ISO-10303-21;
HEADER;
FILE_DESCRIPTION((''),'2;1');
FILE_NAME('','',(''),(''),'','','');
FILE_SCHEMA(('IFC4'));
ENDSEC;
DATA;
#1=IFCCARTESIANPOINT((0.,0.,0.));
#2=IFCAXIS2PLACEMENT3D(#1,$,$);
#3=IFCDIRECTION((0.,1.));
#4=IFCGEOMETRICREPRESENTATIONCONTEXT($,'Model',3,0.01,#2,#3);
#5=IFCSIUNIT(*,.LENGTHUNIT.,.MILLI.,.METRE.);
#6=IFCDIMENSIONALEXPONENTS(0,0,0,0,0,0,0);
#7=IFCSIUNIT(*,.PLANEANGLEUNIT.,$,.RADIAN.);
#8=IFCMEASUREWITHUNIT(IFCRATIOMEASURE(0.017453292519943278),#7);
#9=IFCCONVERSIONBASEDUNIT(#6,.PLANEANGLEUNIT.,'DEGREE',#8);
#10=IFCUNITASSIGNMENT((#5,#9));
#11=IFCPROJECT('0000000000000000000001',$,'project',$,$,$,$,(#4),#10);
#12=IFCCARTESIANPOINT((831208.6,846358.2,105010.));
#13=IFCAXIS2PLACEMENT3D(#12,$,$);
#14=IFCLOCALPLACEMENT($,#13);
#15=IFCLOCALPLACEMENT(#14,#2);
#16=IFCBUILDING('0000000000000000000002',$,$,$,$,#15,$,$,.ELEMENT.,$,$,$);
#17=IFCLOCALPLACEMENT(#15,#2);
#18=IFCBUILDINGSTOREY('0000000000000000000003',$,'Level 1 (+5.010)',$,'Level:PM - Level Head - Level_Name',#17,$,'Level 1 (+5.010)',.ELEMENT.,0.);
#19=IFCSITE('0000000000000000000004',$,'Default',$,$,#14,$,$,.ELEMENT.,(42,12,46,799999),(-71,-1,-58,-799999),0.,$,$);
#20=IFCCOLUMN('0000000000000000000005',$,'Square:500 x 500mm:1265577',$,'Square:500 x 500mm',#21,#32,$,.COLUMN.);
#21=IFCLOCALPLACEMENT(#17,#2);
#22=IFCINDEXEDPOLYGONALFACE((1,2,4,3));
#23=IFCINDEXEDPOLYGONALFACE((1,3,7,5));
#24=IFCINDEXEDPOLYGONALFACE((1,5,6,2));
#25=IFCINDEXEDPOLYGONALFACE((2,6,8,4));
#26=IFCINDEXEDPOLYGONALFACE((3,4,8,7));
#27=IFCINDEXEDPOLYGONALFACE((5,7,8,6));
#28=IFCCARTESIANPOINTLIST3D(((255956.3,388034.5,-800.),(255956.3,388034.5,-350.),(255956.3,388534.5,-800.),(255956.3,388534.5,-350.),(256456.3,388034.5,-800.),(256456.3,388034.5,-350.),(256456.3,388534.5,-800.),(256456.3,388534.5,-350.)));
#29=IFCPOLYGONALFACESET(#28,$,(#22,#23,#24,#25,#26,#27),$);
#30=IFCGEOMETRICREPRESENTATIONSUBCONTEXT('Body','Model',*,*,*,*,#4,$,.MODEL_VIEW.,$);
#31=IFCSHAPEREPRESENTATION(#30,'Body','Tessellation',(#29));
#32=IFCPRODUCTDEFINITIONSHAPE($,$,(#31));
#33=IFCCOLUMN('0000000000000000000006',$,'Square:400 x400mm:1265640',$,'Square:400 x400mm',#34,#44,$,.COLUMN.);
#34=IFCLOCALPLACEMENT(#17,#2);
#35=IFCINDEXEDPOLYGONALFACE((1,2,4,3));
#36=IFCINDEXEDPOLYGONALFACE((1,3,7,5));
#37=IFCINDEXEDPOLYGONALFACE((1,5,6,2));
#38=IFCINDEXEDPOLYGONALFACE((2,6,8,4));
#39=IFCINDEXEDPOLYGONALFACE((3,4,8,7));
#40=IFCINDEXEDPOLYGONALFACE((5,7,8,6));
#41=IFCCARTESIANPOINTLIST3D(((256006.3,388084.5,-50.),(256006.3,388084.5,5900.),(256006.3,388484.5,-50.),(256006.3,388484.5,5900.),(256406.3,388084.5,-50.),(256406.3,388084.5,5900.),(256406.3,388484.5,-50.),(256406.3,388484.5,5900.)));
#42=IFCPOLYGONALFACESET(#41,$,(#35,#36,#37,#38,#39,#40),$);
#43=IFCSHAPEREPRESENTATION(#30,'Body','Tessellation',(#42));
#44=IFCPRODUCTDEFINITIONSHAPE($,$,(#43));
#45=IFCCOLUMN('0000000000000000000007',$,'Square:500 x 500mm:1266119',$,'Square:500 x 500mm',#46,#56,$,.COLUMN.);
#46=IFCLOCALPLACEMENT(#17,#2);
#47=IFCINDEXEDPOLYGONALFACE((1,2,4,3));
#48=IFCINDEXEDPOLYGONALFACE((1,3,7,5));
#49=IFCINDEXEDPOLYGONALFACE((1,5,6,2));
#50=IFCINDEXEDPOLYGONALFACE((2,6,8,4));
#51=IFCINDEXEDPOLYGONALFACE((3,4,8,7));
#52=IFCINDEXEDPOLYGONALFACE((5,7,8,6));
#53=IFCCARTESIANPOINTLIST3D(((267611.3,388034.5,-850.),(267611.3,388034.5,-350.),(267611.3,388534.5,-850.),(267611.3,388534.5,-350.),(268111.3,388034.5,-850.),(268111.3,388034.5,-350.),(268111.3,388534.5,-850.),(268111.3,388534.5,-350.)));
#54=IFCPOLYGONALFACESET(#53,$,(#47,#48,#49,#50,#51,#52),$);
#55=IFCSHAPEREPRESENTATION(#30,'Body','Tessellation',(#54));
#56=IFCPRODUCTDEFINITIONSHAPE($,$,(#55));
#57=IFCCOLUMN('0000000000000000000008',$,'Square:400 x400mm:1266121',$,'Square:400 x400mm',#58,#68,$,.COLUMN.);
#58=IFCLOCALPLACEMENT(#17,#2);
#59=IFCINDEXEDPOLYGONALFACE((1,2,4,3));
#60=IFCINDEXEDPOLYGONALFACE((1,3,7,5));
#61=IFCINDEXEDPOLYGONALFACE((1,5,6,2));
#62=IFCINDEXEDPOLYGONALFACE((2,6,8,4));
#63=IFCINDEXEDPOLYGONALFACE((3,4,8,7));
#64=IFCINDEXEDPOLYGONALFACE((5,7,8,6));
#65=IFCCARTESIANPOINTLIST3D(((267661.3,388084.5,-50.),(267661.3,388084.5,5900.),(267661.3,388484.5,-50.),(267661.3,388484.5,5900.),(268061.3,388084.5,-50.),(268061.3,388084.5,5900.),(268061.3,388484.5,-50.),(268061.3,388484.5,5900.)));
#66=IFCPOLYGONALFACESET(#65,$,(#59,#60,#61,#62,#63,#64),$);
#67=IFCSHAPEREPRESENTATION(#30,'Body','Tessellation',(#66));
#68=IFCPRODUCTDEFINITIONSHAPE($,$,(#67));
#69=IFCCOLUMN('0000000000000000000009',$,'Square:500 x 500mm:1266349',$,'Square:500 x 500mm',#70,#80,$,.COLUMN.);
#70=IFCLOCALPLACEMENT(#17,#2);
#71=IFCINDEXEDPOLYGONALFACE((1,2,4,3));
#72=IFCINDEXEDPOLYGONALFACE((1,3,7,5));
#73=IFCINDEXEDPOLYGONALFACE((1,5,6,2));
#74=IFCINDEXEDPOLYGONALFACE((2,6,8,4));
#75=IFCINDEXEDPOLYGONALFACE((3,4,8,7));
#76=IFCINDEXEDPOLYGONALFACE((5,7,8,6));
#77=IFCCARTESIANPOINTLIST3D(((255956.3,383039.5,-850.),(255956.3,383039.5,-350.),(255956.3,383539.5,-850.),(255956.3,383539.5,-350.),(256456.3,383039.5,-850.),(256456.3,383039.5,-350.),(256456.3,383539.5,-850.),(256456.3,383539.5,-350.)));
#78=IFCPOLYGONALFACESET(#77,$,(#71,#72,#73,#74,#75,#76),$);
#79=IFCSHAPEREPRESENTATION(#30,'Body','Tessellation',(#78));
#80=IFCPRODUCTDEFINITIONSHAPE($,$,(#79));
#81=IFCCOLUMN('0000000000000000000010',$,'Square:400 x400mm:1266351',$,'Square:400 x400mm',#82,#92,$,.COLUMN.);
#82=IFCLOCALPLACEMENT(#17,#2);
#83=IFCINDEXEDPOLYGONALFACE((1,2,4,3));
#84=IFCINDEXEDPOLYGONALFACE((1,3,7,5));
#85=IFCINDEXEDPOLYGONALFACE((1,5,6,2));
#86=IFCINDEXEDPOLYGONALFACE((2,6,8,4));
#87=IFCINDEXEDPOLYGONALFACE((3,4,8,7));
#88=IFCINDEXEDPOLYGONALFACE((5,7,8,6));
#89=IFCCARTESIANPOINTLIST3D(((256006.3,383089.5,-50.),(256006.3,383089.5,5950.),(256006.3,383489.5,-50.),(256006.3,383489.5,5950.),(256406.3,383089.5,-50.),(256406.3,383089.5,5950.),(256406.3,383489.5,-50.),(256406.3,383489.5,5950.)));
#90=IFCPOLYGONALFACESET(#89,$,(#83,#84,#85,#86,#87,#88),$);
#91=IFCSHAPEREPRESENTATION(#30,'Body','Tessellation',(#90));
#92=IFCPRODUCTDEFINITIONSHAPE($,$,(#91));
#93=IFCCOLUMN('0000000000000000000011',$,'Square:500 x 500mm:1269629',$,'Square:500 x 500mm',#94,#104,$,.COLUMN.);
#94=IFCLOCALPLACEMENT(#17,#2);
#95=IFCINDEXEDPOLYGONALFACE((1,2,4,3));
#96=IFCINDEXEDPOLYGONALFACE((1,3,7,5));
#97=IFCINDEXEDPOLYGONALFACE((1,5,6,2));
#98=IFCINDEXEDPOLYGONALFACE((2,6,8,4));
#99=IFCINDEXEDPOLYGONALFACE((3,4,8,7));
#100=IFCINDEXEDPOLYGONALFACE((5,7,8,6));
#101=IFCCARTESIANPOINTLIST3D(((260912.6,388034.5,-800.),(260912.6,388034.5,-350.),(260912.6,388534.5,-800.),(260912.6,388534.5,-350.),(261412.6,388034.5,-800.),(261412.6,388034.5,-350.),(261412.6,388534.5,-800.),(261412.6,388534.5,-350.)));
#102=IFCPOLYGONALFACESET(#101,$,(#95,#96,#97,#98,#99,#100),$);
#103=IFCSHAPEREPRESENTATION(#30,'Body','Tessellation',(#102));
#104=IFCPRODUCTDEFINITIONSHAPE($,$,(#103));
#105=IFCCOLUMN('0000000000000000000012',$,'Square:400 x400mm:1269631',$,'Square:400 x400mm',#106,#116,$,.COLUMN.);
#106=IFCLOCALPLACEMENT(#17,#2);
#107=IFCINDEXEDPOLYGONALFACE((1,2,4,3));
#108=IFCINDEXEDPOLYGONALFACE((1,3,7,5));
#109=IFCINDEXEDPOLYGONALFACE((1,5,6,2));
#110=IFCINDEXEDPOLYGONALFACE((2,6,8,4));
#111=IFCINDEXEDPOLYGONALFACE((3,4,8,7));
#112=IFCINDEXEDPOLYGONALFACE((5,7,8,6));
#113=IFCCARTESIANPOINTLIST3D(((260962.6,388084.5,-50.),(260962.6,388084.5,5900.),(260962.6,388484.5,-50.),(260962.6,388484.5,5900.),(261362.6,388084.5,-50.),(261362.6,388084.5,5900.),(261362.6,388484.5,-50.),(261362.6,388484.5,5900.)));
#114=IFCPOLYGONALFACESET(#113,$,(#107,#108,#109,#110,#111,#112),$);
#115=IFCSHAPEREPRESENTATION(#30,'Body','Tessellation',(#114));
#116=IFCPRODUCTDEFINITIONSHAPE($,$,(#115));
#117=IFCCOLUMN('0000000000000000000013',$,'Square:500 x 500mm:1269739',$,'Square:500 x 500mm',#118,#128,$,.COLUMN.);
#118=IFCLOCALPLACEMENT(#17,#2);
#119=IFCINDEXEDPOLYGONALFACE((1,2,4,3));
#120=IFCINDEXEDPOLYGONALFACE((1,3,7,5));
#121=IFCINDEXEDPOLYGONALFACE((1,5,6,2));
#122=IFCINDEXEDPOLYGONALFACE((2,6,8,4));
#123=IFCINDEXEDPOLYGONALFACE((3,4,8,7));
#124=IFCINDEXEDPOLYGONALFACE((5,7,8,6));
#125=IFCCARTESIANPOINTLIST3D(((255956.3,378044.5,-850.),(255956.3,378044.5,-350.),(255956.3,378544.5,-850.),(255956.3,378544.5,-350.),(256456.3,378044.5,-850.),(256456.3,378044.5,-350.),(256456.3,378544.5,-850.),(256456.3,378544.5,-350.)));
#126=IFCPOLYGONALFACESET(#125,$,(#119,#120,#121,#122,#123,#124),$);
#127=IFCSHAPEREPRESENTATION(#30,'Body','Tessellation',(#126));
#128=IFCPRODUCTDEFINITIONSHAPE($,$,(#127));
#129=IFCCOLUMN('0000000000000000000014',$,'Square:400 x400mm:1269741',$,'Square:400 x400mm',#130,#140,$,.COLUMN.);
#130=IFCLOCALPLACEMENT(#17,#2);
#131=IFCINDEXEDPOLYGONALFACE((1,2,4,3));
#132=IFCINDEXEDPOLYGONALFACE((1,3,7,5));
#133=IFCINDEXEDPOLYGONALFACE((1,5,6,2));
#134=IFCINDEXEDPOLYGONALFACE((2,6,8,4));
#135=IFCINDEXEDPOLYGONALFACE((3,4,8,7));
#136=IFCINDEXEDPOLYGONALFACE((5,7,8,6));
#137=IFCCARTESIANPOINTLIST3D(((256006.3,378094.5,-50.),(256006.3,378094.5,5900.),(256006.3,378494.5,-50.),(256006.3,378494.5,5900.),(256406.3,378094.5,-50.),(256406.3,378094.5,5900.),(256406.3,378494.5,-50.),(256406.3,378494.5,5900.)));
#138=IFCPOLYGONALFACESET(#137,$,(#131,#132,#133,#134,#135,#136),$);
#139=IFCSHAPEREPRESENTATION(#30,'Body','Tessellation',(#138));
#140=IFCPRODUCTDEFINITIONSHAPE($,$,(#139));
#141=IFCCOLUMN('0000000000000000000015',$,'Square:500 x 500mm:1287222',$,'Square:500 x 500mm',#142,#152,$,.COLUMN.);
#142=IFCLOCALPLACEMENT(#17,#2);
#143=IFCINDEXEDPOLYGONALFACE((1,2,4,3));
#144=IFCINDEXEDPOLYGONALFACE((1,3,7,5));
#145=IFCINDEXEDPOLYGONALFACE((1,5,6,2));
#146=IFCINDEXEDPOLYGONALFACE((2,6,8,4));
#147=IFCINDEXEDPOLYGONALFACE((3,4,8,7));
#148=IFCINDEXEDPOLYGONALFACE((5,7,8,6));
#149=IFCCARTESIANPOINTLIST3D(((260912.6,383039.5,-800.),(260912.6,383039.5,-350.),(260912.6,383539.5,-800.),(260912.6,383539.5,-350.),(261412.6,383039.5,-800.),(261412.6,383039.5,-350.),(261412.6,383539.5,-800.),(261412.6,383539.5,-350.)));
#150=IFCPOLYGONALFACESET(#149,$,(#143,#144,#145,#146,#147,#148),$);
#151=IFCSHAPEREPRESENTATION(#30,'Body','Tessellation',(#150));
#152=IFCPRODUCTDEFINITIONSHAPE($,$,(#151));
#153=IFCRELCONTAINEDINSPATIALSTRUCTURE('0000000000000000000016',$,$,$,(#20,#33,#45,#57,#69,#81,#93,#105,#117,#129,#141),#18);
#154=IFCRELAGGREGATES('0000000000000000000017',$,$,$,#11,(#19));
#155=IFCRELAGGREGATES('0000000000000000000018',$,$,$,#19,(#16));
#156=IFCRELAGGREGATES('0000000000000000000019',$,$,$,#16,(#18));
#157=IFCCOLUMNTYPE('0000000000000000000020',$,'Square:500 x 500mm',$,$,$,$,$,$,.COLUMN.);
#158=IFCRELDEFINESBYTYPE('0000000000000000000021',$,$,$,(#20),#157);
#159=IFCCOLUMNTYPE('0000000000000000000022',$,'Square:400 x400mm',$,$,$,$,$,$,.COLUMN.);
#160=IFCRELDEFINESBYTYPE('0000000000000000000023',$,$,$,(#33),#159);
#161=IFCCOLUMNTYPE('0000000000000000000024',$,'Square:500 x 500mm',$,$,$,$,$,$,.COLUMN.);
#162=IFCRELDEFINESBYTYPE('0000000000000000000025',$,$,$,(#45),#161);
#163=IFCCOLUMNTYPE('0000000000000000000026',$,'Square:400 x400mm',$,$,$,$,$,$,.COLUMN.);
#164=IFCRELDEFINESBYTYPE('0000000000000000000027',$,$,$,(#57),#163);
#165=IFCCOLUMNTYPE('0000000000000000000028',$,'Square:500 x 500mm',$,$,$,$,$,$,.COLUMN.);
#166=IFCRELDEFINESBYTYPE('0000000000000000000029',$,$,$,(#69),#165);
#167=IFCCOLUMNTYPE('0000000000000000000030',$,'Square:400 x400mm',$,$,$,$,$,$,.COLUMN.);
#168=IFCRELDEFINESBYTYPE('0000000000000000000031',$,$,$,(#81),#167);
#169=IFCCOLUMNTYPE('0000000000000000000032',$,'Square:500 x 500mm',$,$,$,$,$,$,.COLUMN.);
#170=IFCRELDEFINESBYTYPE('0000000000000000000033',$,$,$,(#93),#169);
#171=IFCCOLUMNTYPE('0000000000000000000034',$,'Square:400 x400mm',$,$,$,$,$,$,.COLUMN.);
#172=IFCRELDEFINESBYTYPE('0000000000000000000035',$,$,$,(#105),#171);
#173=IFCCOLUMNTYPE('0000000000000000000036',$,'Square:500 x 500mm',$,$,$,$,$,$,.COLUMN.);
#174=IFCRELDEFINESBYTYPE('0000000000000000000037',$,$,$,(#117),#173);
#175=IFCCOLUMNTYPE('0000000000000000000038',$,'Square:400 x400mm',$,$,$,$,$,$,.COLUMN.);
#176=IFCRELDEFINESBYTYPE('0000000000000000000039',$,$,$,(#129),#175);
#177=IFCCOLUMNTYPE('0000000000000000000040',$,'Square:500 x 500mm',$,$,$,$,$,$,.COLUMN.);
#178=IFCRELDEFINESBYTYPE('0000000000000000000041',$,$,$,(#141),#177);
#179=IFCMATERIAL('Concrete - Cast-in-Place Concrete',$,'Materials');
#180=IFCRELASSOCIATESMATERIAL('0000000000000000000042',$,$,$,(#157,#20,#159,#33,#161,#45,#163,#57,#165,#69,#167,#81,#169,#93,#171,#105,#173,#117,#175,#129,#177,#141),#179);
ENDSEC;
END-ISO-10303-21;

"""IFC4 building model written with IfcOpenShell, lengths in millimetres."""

from ifc_helpers import new_model, entity, si_unit, converted_unit, direction, frame, origin, place, context, subcontext, project, spatial, indexed_curve, outline, extrude, source, transform, mapped, material, type_object, type_shapes, element, save


model = new_model("IFC4")

# Units and contexts
model_context = context("Model", 3, precision=0.01, world=origin(), true_north=direction((0.0, 1.0)))
body_context = subcontext(model_context, "Body", "Model", "MODEL_VIEW")
ifc_project = project(units=[si_unit("LENGTHUNIT", "METRE", prefix="MILLI"), converted_unit("PLANEANGLEUNIT", "DEGREE", entity("IfcRatioMeasure", 0.017453292519943278), si_unit("PLANEANGLEUNIT", "RADIAN"), dimensions=[0, 0, 0, 0, 0, 0, 0])], contexts=[model_context])

# Site, building, storey
site_placement = place(None, frame((831208.6, 846358.2, 105010.0)))
site = spatial("IfcSite", under=ifc_project, at=site_placement, Name="Default", CompositionType="ELEMENT", RefLatitude=(42, 12, 46, 799999), RefLongitude=(-71, -1, -58, -799999), RefElevation=0.0)
building_placement = place(site_placement, origin())
building = spatial("IfcBuilding", under=site, at=building_placement, CompositionType="ELEMENT")
storey_placement = place(building_placement, origin())
storey = spatial("IfcBuildingStorey", under=building, at=storey_placement, Name="Level 1 (+5.010)", ObjectType="Level:PM - Level Head - Level_Name", LongName="Level 1 (+5.010)", CompositionType="ELEMENT", Elevation=0.0)

# Columns
ifc_material_1 = material(Name="Concrete - Cast-in-Place Concrete", Category="Materials")
column_type_1 = type_object("IfcColumnType", Name="Square:500 x 500mm", PredefinedType="COLUMN", material=ifc_material_1)
shared_shape_1 = source(origin(), body_context, "Body", "SweptSolid", [
    extrude(outline(indexed_curve([(-250.0, -250.0), (250.0, -250.0), (250.0, 250.0), (-250.0, 250.0), (-250.0, -250.0)], self_intersect=False)), frame((256206.3, 388284.5, -800.0), z_axis=(0.0, 0.0, 1.0), x_axis=(0.0, 1.0, 0.0)), (0.0, 0.0, 1.0), 450.0),
])
type_shapes(column_type_1, [shared_shape_1])
column_1_placement = place(storey_placement, origin())
element("IfcColumn", 1, at=column_1_placement, inside=storey, type_object=column_type_1, material=ifc_material_1, Name="Square:500 x 500mm:1265577", ObjectType="Square:500 x 500mm", PredefinedType="COLUMN", context=body_context, shape_type="MappedRepresentation", body=[
    mapped(shared_shape_1, transform((0.0, 0.0, 0.0), scale=1.0)),
])
column_type_2 = type_object("IfcColumnType", Name="Square:400 x400mm", PredefinedType="COLUMN", material=ifc_material_1)
shared_shape_2 = source(origin(), body_context, "Body", "SweptSolid", [
    extrude(outline(indexed_curve([(-200.0, -200.0), (200.0, -200.0), (200.0, 200.0), (-200.0, 200.0), (-200.0, -200.0)], self_intersect=False)), frame((256206.3, 388284.5, -50.0), z_axis=(0.0, 0.0, 1.0), x_axis=(0.0, 1.0, 0.0)), (0.0, 0.0, 1.0), 5950.0),
])
type_shapes(column_type_2, [shared_shape_2])
column_2_placement = place(storey_placement, origin())
element("IfcColumn", 2, at=column_2_placement, inside=storey, type_object=column_type_2, material=ifc_material_1, Name="Square:400 x400mm:1265640", ObjectType="Square:400 x400mm", PredefinedType="COLUMN", context=body_context, shape_type="MappedRepresentation", body=[
    mapped(shared_shape_2, transform((0.0, 0.0, 0.0), scale=1.0)),
])
column_type_3 = type_object("IfcColumnType", Name="Square:500 x 500mm", PredefinedType="COLUMN", material=ifc_material_1)
shared_shape_3 = source(origin(), body_context, "Body", "SweptSolid", [
    extrude(outline(indexed_curve([(-250.0, -250.0), (250.0, -250.0), (250.0, 250.0), (-250.0, 250.0), (-250.0, -250.0)], self_intersect=False)), frame((267861.3, 388284.5, -850.0), z_axis=(0.0, 0.0, 1.0), x_axis=(0.0, 1.0, 0.0)), (0.0, 0.0, 1.0), 500.0),
])
type_shapes(column_type_3, [shared_shape_3])
column_3_placement = place(storey_placement, origin())
element("IfcColumn", 3, at=column_3_placement, inside=storey, type_object=column_type_3, material=ifc_material_1, Name="Square:500 x 500mm:1266119", ObjectType="Square:500 x 500mm", PredefinedType="COLUMN", context=body_context, shape_type="MappedRepresentation", body=[
    mapped(shared_shape_3, transform((0.0, 0.0, 0.0), scale=1.0)),
])
column_type_4 = type_object("IfcColumnType", Name="Square:400 x400mm", PredefinedType="COLUMN", material=ifc_material_1)
shared_shape_4 = source(origin(), body_context, "Body", "SweptSolid", [
    extrude(outline(indexed_curve([(-200.0, -200.0), (200.0, -200.0), (200.0, 200.0), (-200.0, 200.0), (-200.0, -200.0)], self_intersect=False)), frame((267861.3, 388284.5, -50.0), z_axis=(0.0, 0.0, 1.0), x_axis=(0.0, 1.0, 0.0)), (0.0, 0.0, 1.0), 5950.0),
])
type_shapes(column_type_4, [shared_shape_4])
column_4_placement = place(storey_placement, origin())
element("IfcColumn", 4, at=column_4_placement, inside=storey, type_object=column_type_4, material=ifc_material_1, Name="Square:400 x400mm:1266121", ObjectType="Square:400 x400mm", PredefinedType="COLUMN", context=body_context, shape_type="MappedRepresentation", body=[
    mapped(shared_shape_4, transform((0.0, 0.0, 0.0), scale=1.0)),
])
column_type_5 = type_object("IfcColumnType", Name="Square:500 x 500mm", PredefinedType="COLUMN", material=ifc_material_1)
shared_shape_5 = source(origin(), body_context, "Body", "SweptSolid", [
    extrude(outline(indexed_curve([(-250.0, -250.0), (250.0, -250.0), (250.0, 250.0), (-250.0, 250.0), (-250.0, -250.0)], self_intersect=False)), frame((256206.3, 383289.5, -850.0), z_axis=(0.0, 0.0, 1.0), x_axis=(0.0, 1.0, 0.0)), (0.0, 0.0, 1.0), 500.0),
])
type_shapes(column_type_5, [shared_shape_5])
column_5_placement = place(storey_placement, origin())
element("IfcColumn", 5, at=column_5_placement, inside=storey, type_object=column_type_5, material=ifc_material_1, Name="Square:500 x 500mm:1266349", ObjectType="Square:500 x 500mm", PredefinedType="COLUMN", context=body_context, shape_type="MappedRepresentation", body=[
    mapped(shared_shape_5, transform((0.0, 0.0, 0.0), scale=1.0)),
])
column_type_6 = type_object("IfcColumnType", Name="Square:400 x400mm", PredefinedType="COLUMN", material=ifc_material_1)
shared_shape_6 = source(origin(), body_context, "Body", "SweptSolid", [
    extrude(outline(indexed_curve([(-200.0, -200.0), (200.0, -200.0), (200.0, 200.0), (-200.0, 200.0), (-200.0, -200.0)], self_intersect=False)), frame((256206.3, 383289.5, -50.0), z_axis=(0.0, 0.0, 1.0), x_axis=(0.0, 1.0, 0.0)), (0.0, 0.0, 1.0), 6000.0),
])
type_shapes(column_type_6, [shared_shape_6])
column_6_placement = place(storey_placement, origin())
element("IfcColumn", 6, at=column_6_placement, inside=storey, type_object=column_type_6, material=ifc_material_1, Name="Square:400 x400mm:1266351", ObjectType="Square:400 x400mm", PredefinedType="COLUMN", context=body_context, shape_type="MappedRepresentation", body=[
    mapped(shared_shape_6, transform((0.0, 0.0, 0.0), scale=1.0)),
])
column_type_7 = type_object("IfcColumnType", Name="Square:500 x 500mm", PredefinedType="COLUMN", material=ifc_material_1)
shared_shape_7 = source(origin(), body_context, "Body", "SweptSolid", [
    extrude(outline(indexed_curve([(-250.0, -250.0), (250.0, -250.0), (250.0, 250.0), (-250.0, 250.0), (-250.0, -250.0)], self_intersect=False)), frame((261162.6, 388284.5, -800.0), z_axis=(0.0, 0.0, 1.0), x_axis=(0.0, 1.0, 0.0)), (0.0, 0.0, 1.0), 450.0),
])
type_shapes(column_type_7, [shared_shape_7])
column_7_placement = place(storey_placement, origin())
element("IfcColumn", 7, at=column_7_placement, inside=storey, type_object=column_type_7, material=ifc_material_1, Name="Square:500 x 500mm:1269629", ObjectType="Square:500 x 500mm", PredefinedType="COLUMN", context=body_context, shape_type="MappedRepresentation", body=[
    mapped(shared_shape_7, transform((0.0, 0.0, 0.0), scale=1.0)),
])
column_type_8 = type_object("IfcColumnType", Name="Square:400 x400mm", PredefinedType="COLUMN", material=ifc_material_1)
shared_shape_8 = source(origin(), body_context, "Body", "SweptSolid", [
    extrude(outline(indexed_curve([(-200.0, -200.0), (200.0, -200.0), (200.0, 200.0), (-200.0, 200.0), (-200.0, -200.0)], self_intersect=False)), frame((261162.6, 388284.5, -50.0), z_axis=(0.0, 0.0, 1.0), x_axis=(0.0, 1.0, 0.0)), (0.0, 0.0, 1.0), 5950.0),
])
type_shapes(column_type_8, [shared_shape_8])
column_8_placement = place(storey_placement, origin())
element("IfcColumn", 8, at=column_8_placement, inside=storey, type_object=column_type_8, material=ifc_material_1, Name="Square:400 x400mm:1269631", ObjectType="Square:400 x400mm", PredefinedType="COLUMN", context=body_context, shape_type="MappedRepresentation", body=[
    mapped(shared_shape_8, transform((0.0, 0.0, 0.0), scale=1.0)),
])
column_type_9 = type_object("IfcColumnType", Name="Square:500 x 500mm", PredefinedType="COLUMN", material=ifc_material_1)
shared_shape_9 = source(origin(), body_context, "Body", "SweptSolid", [
    extrude(outline(indexed_curve([(-250.0, -250.0), (250.0, -250.0), (250.0, 250.0), (-250.0, 250.0), (-250.0, -250.0)], self_intersect=False)), frame((256206.3, 378294.5, -850.0), z_axis=(0.0, 0.0, 1.0), x_axis=(0.0, 1.0, 0.0)), (0.0, 0.0, 1.0), 500.0),
])
type_shapes(column_type_9, [shared_shape_9])
column_9_placement = place(storey_placement, origin())
element("IfcColumn", 9, at=column_9_placement, inside=storey, type_object=column_type_9, material=ifc_material_1, Name="Square:500 x 500mm:1269739", ObjectType="Square:500 x 500mm", PredefinedType="COLUMN", context=body_context, shape_type="MappedRepresentation", body=[
    mapped(shared_shape_9, transform((0.0, 0.0, 0.0), scale=1.0)),
])
column_type_10 = type_object("IfcColumnType", Name="Square:400 x400mm", PredefinedType="COLUMN", material=ifc_material_1)
shared_shape_10 = source(origin(), body_context, "Body", "SweptSolid", [
    extrude(outline(indexed_curve([(-200.0, -200.0), (200.0, -200.0), (200.0, 200.0), (-200.0, 200.0), (-200.0, -200.0)], self_intersect=False)), frame((256206.3, 378294.5, -50.0), z_axis=(0.0, 0.0, 1.0), x_axis=(0.0, 1.0, 0.0)), (0.0, 0.0, 1.0), 5950.0),
])
type_shapes(column_type_10, [shared_shape_10])
column_10_placement = place(storey_placement, origin())
element("IfcColumn", 10, at=column_10_placement, inside=storey, type_object=column_type_10, material=ifc_material_1, Name="Square:400 x400mm:1269741", ObjectType="Square:400 x400mm", PredefinedType="COLUMN", context=body_context, shape_type="MappedRepresentation", body=[
    mapped(shared_shape_10, transform((0.0, 0.0, 0.0), scale=1.0)),
])
column_type_11 = type_object("IfcColumnType", Name="Square:500 x 500mm", PredefinedType="COLUMN", material=ifc_material_1)
shared_shape_11 = source(origin(), body_context, "Body", "SweptSolid", [
    extrude(outline(indexed_curve([(-250.0, -250.0), (250.0, -250.0), (250.0, 250.0), (-250.0, 250.0), (-250.0, -250.0)], self_intersect=False)), frame((261162.6, 383289.5, -800.0), z_axis=(0.0, 0.0, 1.0), x_axis=(0.0, 1.0, 0.0)), (0.0, 0.0, 1.0), 450.0),
])
type_shapes(column_type_11, [shared_shape_11])
column_11_placement = place(storey_placement, origin())
element("IfcColumn", 11, at=column_11_placement, inside=storey, type_object=column_type_11, material=ifc_material_1, Name="Square:500 x 500mm:1287222", ObjectType="Square:500 x 500mm", PredefinedType="COLUMN", context=body_context, shape_type="MappedRepresentation", body=[
    mapped(shared_shape_11, transform((0.0, 0.0, 0.0), scale=1.0)),
])

save(model, "model.ifc")
